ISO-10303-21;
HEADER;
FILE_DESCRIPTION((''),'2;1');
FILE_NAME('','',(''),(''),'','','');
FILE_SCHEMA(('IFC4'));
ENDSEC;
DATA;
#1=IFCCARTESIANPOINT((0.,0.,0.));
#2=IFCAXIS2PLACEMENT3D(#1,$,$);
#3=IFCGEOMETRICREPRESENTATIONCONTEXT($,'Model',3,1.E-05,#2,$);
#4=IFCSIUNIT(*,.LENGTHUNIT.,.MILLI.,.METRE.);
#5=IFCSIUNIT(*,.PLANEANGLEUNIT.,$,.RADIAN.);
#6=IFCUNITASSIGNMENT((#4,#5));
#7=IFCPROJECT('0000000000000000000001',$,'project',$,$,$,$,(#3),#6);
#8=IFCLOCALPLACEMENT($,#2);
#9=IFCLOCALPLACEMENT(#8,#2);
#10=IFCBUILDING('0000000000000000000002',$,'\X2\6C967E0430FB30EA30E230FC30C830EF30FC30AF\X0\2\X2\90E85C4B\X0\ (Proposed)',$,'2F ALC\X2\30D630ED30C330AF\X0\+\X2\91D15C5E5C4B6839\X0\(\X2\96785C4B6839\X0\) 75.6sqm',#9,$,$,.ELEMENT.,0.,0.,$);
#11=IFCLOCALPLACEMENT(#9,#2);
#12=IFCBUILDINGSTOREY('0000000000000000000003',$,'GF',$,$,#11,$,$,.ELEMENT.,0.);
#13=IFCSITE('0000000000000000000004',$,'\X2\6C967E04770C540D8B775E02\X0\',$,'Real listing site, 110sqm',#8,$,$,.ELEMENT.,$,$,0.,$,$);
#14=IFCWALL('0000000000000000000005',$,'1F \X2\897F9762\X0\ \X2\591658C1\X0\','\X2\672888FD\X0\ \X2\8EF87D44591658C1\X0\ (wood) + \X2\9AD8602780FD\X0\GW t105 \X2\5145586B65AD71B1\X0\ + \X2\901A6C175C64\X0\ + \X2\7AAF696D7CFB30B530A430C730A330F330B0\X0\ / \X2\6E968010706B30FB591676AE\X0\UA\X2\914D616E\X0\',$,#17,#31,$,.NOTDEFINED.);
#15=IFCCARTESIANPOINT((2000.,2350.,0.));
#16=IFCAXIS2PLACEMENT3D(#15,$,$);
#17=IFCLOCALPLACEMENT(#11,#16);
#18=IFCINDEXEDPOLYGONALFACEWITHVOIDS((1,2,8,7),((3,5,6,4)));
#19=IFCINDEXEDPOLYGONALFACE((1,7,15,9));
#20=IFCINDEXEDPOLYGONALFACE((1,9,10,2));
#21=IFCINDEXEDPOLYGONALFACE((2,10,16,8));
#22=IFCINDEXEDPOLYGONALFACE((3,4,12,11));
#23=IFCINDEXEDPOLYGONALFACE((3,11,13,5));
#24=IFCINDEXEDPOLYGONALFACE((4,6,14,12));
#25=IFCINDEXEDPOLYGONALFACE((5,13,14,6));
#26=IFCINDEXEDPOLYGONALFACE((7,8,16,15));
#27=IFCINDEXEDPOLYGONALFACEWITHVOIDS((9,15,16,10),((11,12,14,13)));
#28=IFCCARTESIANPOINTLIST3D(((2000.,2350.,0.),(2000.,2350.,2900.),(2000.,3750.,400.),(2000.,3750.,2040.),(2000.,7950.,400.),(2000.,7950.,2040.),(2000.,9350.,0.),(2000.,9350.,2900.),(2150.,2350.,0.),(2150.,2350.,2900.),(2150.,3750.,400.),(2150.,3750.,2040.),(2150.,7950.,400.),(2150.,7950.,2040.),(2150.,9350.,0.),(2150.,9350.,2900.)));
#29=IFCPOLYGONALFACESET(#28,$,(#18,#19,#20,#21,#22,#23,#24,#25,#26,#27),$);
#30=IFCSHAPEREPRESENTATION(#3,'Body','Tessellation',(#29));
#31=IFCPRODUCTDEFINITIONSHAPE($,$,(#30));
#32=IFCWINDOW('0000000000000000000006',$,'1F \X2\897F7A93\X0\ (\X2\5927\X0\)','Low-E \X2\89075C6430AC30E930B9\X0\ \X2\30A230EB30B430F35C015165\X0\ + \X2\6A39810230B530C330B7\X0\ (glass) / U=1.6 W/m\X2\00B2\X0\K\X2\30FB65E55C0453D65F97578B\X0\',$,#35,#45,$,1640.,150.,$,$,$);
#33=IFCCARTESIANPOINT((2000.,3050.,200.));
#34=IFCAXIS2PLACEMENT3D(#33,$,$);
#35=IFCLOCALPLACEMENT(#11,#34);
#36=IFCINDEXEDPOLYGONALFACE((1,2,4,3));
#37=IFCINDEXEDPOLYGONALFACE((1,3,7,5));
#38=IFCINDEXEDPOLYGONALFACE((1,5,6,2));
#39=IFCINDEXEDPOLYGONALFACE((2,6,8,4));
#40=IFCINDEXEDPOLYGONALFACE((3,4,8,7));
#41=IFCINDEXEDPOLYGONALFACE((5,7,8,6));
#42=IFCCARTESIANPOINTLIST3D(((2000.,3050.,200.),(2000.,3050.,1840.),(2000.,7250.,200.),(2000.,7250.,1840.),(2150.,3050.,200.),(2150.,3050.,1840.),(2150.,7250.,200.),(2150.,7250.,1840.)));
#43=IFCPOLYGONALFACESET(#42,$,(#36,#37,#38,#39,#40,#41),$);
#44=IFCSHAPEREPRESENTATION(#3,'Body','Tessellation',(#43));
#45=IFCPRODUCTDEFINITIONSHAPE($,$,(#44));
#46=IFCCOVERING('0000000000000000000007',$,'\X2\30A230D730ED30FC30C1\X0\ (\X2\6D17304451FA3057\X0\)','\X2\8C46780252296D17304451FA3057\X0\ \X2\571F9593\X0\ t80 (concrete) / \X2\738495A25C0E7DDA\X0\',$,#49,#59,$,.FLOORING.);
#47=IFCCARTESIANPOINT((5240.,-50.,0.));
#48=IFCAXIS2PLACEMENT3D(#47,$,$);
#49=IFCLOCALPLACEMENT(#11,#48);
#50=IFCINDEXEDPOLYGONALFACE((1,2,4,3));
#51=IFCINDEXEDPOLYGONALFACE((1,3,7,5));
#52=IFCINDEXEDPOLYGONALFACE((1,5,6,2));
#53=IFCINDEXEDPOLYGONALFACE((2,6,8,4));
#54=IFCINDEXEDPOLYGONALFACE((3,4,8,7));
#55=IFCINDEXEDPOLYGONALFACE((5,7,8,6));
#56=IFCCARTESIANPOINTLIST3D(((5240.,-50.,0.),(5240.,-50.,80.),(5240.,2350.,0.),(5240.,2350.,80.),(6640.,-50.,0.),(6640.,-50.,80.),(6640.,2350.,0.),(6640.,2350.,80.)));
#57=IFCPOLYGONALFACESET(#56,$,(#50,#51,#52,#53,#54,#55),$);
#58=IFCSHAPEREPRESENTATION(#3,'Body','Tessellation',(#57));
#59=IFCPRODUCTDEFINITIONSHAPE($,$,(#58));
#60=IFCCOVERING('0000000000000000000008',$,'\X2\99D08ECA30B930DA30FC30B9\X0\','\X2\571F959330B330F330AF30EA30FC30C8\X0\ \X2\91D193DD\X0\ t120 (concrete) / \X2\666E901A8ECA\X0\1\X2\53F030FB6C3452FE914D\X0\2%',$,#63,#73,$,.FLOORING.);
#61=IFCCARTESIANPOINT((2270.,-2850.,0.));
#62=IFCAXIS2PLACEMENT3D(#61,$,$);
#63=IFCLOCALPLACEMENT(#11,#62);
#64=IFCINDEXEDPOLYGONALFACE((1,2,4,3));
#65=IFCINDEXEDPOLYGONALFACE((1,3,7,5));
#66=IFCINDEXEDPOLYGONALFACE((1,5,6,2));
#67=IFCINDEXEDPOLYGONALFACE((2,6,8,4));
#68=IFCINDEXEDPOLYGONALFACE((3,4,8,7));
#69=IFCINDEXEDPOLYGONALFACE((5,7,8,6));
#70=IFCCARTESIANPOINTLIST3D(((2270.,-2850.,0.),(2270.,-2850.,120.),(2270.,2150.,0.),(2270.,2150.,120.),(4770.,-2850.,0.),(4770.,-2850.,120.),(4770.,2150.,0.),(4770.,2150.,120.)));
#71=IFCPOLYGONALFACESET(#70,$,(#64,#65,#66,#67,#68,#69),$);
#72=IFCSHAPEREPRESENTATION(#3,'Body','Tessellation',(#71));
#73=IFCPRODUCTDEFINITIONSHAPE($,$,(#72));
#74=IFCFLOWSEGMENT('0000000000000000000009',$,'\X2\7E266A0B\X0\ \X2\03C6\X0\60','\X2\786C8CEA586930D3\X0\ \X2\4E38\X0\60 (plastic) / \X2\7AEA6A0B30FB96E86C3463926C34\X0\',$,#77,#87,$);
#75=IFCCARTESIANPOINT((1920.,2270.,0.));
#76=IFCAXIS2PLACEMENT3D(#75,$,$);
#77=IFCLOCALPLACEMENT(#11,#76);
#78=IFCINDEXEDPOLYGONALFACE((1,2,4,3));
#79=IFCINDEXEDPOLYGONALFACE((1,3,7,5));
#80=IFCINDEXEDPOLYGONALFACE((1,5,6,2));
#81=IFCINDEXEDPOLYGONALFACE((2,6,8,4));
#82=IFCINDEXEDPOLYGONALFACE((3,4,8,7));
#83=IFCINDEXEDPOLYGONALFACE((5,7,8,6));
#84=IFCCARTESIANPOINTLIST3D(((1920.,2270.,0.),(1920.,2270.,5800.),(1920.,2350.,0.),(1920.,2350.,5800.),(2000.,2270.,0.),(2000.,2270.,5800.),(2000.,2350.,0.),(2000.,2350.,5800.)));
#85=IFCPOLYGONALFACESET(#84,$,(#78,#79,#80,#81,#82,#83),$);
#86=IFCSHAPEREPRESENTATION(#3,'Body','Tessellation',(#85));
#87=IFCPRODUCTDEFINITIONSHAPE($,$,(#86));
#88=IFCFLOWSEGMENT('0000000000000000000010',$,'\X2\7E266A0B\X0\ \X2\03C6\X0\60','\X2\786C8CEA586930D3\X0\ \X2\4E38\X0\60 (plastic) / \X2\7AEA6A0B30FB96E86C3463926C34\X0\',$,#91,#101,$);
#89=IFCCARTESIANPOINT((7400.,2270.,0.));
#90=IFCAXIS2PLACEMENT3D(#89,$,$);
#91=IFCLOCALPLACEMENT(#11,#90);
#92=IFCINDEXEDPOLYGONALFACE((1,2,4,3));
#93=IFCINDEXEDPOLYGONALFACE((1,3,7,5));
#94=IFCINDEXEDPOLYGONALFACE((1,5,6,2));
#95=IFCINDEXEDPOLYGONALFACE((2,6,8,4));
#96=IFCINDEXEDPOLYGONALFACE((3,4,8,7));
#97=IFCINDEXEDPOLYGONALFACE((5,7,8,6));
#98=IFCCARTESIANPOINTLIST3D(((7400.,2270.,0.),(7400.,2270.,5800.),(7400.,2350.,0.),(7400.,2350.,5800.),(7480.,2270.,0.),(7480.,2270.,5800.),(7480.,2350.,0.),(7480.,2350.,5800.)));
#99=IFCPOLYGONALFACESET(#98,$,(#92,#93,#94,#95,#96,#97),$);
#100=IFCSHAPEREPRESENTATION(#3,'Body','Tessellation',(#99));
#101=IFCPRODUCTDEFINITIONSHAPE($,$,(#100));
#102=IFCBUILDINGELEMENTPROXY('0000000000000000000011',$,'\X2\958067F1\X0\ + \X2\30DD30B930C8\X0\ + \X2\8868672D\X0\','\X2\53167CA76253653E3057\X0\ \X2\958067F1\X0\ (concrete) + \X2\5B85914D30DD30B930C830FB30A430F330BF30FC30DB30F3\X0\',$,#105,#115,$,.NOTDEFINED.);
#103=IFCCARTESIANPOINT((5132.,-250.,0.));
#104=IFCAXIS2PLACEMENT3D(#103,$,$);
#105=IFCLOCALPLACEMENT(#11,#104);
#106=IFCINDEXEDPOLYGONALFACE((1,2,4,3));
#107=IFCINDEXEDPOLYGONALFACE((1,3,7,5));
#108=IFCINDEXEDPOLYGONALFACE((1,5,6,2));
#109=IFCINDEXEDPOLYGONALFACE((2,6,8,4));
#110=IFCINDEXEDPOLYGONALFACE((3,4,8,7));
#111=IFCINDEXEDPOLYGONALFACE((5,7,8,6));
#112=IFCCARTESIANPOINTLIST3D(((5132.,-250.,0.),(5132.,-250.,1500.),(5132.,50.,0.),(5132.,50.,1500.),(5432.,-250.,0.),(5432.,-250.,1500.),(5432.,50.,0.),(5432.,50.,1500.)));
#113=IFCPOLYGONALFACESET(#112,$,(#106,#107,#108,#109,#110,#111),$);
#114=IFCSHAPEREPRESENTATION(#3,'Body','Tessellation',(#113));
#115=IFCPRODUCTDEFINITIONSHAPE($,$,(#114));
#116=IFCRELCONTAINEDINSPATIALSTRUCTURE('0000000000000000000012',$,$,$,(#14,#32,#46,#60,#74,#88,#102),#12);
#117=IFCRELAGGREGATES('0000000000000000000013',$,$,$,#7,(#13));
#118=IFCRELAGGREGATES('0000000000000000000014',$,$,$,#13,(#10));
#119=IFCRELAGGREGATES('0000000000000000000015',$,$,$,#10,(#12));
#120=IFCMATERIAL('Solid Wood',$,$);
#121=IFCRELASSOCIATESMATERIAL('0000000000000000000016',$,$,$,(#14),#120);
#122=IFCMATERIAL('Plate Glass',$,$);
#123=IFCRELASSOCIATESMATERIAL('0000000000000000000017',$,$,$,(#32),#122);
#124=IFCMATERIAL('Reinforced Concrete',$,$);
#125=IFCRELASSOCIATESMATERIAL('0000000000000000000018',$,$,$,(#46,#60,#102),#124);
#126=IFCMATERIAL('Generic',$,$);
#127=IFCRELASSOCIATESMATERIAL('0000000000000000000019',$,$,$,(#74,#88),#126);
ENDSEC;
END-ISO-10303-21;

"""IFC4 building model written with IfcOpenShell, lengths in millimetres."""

from ifc_helpers import new_model, si_unit, frame, frame_2d, origin, place, context, project, spatial, rectangle, extrude, material, element, fill, save


model = new_model("IFC4")

# Units and contexts
model_context = context("Model", 3, precision=1e-05, world=origin())
ifc_project = project(units=[si_unit("LENGTHUNIT", "METRE", prefix="MILLI"), si_unit("PLANEANGLEUNIT", "RADIAN")], contexts=[model_context])

# Site, building, storey
site_placement = place(None, origin())
site = spatial("IfcSite", under=ifc_project, at=site_placement, Name="沖縄県名護市", ObjectType="Real listing site, 110sqm", CompositionType="ELEMENT", RefElevation=0.0)
building_placement = place(site_placement, origin())
building = spatial("IfcBuilding", under=site, at=building_placement, Name="沖縄・リモートワーク2部屋 (Proposed)", ObjectType="2F ALCブロック+金属屋根(陸屋根) 75.6sqm", CompositionType="ELEMENT", ElevationOfRefHeight=0.0, ElevationOfTerrain=0.0)
storey_placement = place(building_placement, origin())
storey = spatial("IfcBuildingStorey", under=building, at=storey_placement, Name="GF", CompositionType="ELEMENT", Elevation=0.0)

# Shared definitions
ifc_material_1 = material(Name="Solid Wood")

# Shared definitions
ifc_material_2 = material(Name="Reinforced Concrete")

# Shared definitions
ifc_material_3 = material(Name="Plate Glass")

# Wall, opening, window
wall_1_placement = place(storey_placement, frame((2000.0, 2350.0, 0.0)))
wall_1 = element("IfcWall", 1, at=wall_1_placement, inside=storey, material=ifc_material_1, Name="1F 西面 外壁", Description="木製 軸組外壁 (wood) + 高性能GW t105 充填断熱 + 通気層 + 窯業系サイディング / 準耐火・外皮UA配慮", PredefinedType="NOTDEFINED", context=model_context, shape_type="SweptSolid", body=[
    extrude(rectangle(XDim=150.0, YDim=7000.0, at=frame_2d((75.0, 3500.0))), frame((2000.0, 2350.0, 0.0)), (0.0, 0.0, 1.0), 2900.0),
])
opening_1_placement = place(storey_placement, frame((2000.0, 3050.0, 200.0)))
opening_1 = element("IfcOpeningElement", 2, at=opening_1_placement, cuts=wall_1, PredefinedType="NOTDEFINED", context=model_context, shape_type="SweptSolid", body=[
    extrude(rectangle(XDim=150.0, YDim=4200.0, at=frame_2d((75.0, 2100.0))), frame((2000.0, 3050.0, 200.0)), (0.0, 0.0, 1.0), 1640.0),
])
window_1_placement = place(storey_placement, frame((2000.0, 3050.0, 200.0)))
window_1 = element("IfcWindow", 3, at=window_1_placement, inside=storey, material=ifc_material_3, Name="1F 西窓 (大)", Description="Low-E 複層ガラス アルゴン封入 + 樹脂サッシ (glass) / U=1.6 W/m²K・日射取得型", OverallHeight=1640.0, OverallWidth=150.0, context=model_context, shape_type="SweptSolid", body=[
    extrude(rectangle(XDim=150.0, YDim=4200.0, at=frame_2d((75.0, 2100.0))), frame((2000.0, 3050.0, 200.0)), (0.0, 0.0, 1.0), 1640.0),
])
fill(opening_1, window_1)

# Coverings
covering_1_placement = place(storey_placement, frame((5240.0, -50.0, 0.0)))
element("IfcCovering", 4, at=covering_1_placement, inside=storey, material=ifc_material_2, Name="アプローチ (洗い出し)", Description="豆砂利洗い出し 土間 t80 (concrete) / 玄関導線", PredefinedType="FLOORING", context=model_context, shape_type="SweptSolid", body=[
    extrude(rectangle(XDim=1400.0, YDim=2400.0, at=frame_2d((700.0, 1200.0))), frame((5240.0, -50.0, 0.0)), (0.0, 0.0, 1.0), 80.0),
])
covering_2_placement = place(storey_placement, frame((2270.0, -2850.0, 0.0)))
element("IfcCovering", 5, at=covering_2_placement, inside=storey, material=ifc_material_2, Name="駐車スペース", Description="土間コンクリート 金鏝 t120 (concrete) / 普通車1台・水勾配2%", PredefinedType="FLOORING", context=model_context, shape_type="SweptSolid", body=[
    extrude(rectangle(XDim=2500.0, YDim=5000.0, at=frame_2d((1250.0, 2500.0))), frame((2270.0, -2850.0, 0.0)), (0.0, 0.0, 1.0), 120.0),
])

# Flow segments
ifc_material_4 = material(Name="Generic")
flow_segment_1_placement = place(storey_placement, frame((1920.0, 2270.0, 0.0)))
element("IfcFlowSegment", 6, at=flow_segment_1_placement, inside=storey, material=ifc_material_4, Name="縦樋 φ60", Description="硬質塩ビ 丸60 (plastic) / 竪樋・雨水排水", context=model_context, shape_type="SweptSolid", body=[
    extrude(rectangle(XDim=80.0, YDim=80.0, at=frame_2d((40.0, 40.0))), frame((1920.0, 2270.0, 0.0)), (0.0, 0.0, 1.0), 5800.0),
])
flow_segment_2_placement = place(storey_placement, frame((7400.0, 2270.0, 0.0)))
element("IfcFlowSegment", 7, at=flow_segment_2_placement, inside=storey, material=ifc_material_4, Name="縦樋 φ60", Description="硬質塩ビ 丸60 (plastic) / 竪樋・雨水排水", context=model_context, shape_type="SweptSolid", body=[
    extrude(rectangle(XDim=80.0, YDim=80.0, at=frame_2d((40.0, 40.0))), frame((7400.0, 2270.0, 0.0)), (0.0, 0.0, 1.0), 5800.0),
])

# Building element proxy
proxy_placement = place(storey_placement, frame((5132.0, -250.0, 0.0)))
element("IfcBuildingElementProxy", 8, at=proxy_placement, inside=storey, material=ifc_material_2, Name="門柱 + ポスト + 表札", Description="化粧打放し 門柱 (concrete) + 宅配ポスト・インターホン", PredefinedType="NOTDEFINED", context=model_context, shape_type="SweptSolid", body=[
    extrude(rectangle(XDim=300.0, YDim=300.0, at=frame_2d((150.0, 150.0))), frame((5132.0, -250.0, 0.0)), (0.0, 0.0, 1.0), 1500.0),
])

save(model, "model.ifc")
